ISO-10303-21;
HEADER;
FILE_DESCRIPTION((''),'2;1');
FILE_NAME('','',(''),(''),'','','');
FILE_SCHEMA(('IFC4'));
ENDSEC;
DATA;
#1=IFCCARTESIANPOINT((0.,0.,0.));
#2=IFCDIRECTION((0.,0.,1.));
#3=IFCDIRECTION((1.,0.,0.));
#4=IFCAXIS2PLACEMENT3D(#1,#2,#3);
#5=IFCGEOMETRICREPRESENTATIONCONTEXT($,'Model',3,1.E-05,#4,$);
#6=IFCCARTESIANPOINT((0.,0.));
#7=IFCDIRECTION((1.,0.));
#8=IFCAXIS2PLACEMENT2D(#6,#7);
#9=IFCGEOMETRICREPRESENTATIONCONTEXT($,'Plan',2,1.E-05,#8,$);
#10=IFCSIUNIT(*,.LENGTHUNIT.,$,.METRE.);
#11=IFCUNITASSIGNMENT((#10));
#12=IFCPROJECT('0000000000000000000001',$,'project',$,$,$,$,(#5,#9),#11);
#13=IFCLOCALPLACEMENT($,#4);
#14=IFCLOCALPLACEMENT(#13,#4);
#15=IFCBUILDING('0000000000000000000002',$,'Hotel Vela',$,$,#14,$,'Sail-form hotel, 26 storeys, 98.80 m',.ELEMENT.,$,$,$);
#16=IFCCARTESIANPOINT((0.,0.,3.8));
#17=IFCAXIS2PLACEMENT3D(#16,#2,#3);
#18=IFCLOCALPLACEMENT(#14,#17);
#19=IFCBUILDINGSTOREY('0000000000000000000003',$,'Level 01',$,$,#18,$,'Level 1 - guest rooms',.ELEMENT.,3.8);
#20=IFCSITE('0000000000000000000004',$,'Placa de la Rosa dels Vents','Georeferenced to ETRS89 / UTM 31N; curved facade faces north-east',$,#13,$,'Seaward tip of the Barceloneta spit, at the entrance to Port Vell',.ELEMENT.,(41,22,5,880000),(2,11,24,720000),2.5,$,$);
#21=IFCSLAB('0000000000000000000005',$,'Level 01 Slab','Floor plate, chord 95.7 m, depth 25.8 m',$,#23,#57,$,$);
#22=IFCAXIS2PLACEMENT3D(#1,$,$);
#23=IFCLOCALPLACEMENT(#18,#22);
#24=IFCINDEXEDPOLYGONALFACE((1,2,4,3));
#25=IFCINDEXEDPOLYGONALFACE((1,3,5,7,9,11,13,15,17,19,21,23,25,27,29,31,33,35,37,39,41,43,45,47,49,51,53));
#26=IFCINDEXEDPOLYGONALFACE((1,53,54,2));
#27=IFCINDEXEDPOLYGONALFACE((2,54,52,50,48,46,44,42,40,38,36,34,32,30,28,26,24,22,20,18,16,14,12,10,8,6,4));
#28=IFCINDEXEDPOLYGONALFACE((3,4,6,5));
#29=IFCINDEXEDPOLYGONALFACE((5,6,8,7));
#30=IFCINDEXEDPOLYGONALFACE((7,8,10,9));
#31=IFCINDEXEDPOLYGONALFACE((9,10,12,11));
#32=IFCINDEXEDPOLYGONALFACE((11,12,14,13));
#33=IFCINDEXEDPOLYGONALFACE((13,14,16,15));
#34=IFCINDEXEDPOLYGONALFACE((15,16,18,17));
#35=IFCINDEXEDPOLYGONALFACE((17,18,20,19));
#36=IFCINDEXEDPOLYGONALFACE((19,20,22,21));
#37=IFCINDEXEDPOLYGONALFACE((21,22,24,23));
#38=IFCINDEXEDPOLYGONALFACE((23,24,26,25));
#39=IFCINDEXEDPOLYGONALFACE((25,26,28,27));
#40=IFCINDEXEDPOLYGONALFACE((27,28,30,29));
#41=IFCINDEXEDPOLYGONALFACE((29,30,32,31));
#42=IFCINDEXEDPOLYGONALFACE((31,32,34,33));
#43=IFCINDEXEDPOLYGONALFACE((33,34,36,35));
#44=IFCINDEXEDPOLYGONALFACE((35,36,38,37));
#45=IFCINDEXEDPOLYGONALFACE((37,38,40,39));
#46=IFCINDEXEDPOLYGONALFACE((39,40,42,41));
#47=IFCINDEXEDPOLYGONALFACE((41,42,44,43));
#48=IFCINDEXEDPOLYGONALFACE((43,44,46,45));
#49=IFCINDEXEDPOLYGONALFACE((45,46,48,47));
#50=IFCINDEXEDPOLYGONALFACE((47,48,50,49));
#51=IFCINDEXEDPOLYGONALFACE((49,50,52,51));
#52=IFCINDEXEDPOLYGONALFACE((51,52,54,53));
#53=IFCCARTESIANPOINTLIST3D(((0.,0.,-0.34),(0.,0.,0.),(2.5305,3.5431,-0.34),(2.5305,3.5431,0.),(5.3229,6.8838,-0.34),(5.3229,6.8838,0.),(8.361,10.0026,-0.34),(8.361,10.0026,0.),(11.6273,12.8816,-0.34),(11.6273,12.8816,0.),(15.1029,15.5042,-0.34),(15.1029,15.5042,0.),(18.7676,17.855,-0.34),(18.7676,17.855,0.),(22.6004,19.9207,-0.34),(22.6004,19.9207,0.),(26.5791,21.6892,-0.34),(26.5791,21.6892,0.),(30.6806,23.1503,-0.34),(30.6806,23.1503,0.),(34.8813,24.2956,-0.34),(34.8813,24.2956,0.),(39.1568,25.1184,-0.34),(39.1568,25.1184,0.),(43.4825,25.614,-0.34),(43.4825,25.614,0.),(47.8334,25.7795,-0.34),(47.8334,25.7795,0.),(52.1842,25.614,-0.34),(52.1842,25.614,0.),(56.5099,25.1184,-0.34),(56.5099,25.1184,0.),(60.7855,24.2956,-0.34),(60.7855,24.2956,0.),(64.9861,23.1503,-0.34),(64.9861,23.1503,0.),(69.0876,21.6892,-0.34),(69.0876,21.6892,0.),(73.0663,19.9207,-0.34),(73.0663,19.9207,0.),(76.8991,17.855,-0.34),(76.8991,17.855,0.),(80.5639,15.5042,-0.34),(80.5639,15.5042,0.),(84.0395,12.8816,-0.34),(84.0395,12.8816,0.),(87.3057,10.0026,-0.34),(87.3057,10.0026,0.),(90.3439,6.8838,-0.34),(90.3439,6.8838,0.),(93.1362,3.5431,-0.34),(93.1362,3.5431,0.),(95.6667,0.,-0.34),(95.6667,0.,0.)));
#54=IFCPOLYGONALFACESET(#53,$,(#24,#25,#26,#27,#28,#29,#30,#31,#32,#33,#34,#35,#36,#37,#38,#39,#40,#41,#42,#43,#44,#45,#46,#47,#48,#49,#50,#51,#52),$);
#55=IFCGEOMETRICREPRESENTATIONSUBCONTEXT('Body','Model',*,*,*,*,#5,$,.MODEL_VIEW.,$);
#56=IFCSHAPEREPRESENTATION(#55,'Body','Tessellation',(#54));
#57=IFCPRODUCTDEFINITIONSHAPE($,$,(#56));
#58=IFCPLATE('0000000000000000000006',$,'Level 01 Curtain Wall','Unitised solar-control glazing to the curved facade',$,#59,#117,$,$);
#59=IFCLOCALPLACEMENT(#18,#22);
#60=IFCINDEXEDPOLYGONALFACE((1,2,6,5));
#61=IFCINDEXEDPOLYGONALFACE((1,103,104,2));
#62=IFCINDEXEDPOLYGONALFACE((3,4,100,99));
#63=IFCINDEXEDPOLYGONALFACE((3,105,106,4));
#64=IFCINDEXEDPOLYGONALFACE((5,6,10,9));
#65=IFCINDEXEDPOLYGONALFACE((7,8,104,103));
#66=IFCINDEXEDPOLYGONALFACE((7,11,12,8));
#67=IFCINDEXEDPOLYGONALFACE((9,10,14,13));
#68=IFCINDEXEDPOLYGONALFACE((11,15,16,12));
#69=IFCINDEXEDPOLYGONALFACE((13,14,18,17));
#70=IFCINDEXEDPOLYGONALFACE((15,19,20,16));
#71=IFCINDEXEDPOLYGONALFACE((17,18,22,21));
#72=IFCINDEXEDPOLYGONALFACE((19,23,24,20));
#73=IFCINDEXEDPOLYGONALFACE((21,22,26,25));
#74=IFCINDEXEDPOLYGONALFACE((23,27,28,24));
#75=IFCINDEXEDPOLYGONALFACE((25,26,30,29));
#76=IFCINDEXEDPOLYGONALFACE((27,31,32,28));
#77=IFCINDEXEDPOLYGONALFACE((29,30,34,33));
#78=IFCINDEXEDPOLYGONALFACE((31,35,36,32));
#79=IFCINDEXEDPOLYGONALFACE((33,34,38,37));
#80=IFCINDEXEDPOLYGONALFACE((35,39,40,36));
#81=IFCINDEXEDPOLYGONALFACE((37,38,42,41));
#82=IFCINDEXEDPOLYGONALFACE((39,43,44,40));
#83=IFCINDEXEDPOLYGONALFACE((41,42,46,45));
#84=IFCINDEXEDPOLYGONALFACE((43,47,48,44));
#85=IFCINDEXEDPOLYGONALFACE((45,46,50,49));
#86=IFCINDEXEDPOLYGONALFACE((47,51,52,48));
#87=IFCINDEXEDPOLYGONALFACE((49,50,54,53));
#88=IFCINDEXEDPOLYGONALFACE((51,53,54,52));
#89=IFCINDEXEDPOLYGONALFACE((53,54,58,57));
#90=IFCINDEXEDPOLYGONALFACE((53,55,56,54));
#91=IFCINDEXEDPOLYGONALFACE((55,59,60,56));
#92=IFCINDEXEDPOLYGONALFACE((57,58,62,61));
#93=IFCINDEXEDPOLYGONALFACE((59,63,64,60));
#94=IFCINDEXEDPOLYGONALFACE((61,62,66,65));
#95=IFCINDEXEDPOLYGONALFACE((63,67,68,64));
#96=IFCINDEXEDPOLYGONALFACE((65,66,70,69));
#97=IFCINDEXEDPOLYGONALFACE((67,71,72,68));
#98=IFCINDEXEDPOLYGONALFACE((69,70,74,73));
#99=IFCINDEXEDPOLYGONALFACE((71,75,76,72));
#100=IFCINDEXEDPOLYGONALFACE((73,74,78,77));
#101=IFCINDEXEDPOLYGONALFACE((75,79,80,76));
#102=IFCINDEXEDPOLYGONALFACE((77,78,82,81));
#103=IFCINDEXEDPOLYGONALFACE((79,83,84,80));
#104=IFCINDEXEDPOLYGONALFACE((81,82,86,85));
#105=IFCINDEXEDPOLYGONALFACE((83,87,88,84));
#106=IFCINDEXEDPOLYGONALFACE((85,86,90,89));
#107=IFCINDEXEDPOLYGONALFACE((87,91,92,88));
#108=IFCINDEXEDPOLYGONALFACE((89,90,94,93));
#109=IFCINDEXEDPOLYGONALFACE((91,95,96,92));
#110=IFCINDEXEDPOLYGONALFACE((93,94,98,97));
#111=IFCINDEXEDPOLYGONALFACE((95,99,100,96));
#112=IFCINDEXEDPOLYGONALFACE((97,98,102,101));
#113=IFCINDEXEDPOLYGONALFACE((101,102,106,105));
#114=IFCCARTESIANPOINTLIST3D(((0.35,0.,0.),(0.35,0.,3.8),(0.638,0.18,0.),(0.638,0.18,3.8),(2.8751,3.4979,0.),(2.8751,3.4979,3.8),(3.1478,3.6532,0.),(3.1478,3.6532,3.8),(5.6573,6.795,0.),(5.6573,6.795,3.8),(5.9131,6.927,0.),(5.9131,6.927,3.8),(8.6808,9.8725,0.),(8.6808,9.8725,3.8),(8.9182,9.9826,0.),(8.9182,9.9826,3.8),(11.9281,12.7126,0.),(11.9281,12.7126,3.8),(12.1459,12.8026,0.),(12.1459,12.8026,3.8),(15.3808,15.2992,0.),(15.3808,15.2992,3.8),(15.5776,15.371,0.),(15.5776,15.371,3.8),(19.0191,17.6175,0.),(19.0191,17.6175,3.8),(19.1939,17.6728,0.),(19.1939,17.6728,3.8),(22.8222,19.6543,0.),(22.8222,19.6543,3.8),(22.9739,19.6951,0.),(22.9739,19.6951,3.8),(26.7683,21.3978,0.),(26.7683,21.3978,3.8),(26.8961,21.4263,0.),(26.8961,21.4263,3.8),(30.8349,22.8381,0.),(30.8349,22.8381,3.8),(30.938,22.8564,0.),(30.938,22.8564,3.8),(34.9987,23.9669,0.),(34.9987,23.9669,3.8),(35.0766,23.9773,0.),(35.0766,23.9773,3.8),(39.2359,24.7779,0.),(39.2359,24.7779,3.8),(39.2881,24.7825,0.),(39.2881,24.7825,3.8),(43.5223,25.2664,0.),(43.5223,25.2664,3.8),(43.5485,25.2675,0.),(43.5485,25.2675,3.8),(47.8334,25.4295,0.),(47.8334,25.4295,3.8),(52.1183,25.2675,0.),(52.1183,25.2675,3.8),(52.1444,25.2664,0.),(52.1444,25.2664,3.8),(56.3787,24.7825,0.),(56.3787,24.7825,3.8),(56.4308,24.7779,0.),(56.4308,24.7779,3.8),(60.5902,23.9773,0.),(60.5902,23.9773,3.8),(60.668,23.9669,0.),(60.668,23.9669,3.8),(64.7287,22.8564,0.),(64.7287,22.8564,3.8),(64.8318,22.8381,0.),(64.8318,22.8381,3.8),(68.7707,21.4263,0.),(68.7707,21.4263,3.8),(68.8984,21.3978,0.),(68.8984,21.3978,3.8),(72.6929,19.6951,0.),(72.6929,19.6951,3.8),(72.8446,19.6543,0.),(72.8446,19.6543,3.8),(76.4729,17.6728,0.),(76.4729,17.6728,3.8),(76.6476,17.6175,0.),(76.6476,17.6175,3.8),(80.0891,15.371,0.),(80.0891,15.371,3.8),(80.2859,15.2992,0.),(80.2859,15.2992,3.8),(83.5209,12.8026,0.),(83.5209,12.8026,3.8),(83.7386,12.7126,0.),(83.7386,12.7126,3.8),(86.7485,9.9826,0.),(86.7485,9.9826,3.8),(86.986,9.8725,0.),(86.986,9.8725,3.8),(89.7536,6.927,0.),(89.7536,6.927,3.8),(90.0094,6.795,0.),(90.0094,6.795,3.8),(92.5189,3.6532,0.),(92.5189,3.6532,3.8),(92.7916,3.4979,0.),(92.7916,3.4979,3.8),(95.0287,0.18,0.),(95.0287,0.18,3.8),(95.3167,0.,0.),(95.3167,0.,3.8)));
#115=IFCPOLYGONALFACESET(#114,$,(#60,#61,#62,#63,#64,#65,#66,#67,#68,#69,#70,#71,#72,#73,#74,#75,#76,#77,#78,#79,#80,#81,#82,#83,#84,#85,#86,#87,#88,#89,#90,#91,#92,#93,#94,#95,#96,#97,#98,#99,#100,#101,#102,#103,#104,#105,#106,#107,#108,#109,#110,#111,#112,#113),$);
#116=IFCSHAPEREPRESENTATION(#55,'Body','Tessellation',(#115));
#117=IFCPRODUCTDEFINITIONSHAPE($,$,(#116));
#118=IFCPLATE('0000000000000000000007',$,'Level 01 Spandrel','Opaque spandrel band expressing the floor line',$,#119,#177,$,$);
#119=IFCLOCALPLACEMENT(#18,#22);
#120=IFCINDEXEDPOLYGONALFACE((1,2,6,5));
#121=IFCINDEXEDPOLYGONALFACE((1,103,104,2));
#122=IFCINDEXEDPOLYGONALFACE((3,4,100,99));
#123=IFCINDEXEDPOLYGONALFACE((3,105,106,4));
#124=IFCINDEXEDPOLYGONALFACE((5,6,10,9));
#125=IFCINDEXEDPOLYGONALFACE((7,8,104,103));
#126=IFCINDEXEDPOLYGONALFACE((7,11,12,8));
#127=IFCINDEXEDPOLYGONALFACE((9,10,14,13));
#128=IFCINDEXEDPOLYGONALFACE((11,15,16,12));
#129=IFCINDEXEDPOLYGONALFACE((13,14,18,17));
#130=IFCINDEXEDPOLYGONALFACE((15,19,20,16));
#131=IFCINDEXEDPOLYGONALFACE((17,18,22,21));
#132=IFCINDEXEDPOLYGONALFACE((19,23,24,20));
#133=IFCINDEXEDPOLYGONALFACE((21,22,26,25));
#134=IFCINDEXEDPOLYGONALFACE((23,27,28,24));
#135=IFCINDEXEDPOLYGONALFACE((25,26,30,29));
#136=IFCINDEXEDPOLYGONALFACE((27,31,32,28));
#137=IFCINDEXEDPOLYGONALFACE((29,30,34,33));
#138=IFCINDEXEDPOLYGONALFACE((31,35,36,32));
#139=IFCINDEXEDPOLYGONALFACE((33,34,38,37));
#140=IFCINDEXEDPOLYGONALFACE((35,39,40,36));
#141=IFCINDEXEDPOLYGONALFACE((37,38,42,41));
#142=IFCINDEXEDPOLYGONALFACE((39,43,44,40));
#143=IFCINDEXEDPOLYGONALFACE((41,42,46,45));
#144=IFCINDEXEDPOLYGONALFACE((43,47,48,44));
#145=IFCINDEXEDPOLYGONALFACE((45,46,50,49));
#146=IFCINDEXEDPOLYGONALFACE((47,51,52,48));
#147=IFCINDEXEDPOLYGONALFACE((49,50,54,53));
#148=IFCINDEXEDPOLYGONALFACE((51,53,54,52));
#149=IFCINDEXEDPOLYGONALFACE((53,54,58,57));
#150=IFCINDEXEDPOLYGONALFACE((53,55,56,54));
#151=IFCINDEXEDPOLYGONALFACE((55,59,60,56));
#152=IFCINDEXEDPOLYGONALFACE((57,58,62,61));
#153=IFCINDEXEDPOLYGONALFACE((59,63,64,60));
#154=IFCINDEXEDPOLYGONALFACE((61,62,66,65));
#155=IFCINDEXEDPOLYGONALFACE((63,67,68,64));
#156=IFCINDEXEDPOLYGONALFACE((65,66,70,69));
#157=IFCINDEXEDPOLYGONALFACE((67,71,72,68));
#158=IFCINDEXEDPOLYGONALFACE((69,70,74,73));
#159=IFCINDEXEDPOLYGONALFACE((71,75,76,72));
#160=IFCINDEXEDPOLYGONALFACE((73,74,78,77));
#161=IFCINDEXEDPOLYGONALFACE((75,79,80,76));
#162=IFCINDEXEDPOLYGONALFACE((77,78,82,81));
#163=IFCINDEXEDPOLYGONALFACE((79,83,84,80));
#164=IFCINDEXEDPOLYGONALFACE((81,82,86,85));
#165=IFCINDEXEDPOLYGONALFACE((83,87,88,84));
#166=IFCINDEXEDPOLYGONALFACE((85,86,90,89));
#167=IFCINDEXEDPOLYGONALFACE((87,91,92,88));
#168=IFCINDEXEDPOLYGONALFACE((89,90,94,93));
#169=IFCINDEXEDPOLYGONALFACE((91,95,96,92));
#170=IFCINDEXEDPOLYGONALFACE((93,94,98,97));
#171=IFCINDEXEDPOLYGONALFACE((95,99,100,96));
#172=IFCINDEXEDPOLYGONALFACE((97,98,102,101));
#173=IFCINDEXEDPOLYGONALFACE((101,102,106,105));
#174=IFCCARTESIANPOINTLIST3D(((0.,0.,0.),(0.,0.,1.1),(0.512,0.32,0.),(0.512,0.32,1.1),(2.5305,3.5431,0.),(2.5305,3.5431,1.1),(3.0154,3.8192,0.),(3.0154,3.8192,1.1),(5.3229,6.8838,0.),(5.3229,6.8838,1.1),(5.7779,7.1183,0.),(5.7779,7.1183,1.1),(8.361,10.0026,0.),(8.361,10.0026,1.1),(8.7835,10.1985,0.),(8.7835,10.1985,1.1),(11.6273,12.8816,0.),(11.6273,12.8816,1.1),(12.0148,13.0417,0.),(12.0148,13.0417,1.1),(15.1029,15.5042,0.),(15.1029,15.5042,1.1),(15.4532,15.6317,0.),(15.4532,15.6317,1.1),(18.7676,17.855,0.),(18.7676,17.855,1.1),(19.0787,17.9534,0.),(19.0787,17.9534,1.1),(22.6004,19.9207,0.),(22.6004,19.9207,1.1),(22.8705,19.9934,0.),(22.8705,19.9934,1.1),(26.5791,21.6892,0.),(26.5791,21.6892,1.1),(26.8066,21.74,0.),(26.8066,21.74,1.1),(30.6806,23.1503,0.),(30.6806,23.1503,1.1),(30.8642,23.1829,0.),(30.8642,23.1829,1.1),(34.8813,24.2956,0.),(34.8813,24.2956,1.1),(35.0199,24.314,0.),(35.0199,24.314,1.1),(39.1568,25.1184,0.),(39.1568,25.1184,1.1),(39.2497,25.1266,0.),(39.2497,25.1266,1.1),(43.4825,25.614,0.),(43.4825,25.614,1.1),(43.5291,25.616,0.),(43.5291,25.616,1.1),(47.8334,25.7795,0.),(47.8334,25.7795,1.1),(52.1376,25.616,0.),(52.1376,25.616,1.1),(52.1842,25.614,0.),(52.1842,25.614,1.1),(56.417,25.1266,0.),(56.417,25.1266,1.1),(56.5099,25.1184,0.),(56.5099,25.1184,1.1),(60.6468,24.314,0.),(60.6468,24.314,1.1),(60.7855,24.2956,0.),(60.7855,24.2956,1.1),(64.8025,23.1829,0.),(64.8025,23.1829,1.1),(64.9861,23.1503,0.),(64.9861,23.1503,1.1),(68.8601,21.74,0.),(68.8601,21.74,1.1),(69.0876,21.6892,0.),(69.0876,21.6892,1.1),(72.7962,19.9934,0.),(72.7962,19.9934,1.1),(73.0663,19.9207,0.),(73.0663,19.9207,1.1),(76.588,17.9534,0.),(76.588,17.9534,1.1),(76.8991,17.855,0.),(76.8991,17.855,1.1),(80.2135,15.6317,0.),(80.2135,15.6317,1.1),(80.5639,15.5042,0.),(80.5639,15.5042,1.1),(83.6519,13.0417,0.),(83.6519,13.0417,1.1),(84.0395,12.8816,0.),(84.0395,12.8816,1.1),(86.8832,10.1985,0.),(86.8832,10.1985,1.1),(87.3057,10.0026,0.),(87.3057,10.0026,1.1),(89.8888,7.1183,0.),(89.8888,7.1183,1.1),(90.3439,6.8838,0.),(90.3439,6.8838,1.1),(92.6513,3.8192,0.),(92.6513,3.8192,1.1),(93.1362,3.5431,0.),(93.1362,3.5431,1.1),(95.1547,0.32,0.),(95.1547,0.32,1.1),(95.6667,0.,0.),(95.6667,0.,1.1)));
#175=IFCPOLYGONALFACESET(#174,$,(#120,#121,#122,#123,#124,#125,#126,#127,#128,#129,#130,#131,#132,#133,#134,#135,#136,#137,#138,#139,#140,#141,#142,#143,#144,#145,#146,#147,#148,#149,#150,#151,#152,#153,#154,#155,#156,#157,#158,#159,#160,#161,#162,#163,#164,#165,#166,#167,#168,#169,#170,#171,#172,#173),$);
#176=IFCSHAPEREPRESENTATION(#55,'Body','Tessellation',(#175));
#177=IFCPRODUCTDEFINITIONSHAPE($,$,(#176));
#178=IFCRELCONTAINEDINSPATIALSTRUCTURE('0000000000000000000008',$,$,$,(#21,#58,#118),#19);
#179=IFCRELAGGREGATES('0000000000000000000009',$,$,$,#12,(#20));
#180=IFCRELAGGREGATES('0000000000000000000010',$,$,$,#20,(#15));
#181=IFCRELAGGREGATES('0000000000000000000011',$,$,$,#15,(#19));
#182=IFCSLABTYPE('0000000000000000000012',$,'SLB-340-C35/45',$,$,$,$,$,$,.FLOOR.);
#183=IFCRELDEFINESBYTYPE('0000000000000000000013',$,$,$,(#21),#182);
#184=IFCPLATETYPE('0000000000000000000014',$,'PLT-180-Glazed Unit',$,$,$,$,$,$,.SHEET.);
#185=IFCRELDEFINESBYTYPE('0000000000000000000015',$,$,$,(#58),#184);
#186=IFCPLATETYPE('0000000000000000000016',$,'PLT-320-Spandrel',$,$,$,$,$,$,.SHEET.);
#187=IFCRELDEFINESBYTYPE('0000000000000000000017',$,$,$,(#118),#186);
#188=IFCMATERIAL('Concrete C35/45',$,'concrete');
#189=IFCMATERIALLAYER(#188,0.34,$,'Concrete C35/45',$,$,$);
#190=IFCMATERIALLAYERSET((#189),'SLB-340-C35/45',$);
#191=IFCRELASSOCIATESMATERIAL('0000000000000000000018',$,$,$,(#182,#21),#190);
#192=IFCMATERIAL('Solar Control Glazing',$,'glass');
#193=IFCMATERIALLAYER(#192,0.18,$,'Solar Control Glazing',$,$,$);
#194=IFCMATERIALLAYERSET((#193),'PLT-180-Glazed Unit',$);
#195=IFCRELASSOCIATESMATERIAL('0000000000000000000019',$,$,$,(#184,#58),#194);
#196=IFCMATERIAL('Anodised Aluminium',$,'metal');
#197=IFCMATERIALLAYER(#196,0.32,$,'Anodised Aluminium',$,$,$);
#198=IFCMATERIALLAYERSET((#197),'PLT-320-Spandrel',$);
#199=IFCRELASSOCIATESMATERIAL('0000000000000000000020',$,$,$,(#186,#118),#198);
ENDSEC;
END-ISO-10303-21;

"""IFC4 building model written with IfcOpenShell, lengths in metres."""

from ifc_helpers import new_model, si_unit, frame, origin_with_axes, origin_2d_with_axis, place, context, subcontext, project, spatial, line, indexed_curve, outline, extrude, material, layer, layer_set, layer_usage, type_object, element, save


model = new_model("IFC4")

# Units and contexts
model_context = context("Model", 3, precision=1e-05, world=origin_with_axes())
plan_context = context("Plan", 2, precision=1e-05, world=origin_2d_with_axis())
body_context = subcontext(model_context, "Body", "Model", "MODEL_VIEW")
ifc_project = project(units=[si_unit("LENGTHUNIT", "METRE")], contexts=[model_context, plan_context])

# Site, building, storey
site_placement = place(None, origin_with_axes())
site = spatial("IfcSite", under=ifc_project, at=site_placement, Name="Placa de la Rosa dels Vents", Description="Georeferenced to ETRS89 / UTM 31N; curved facade faces north-east", LongName="Seaward tip of the Barceloneta spit, at the entrance to Port Vell", CompositionType="ELEMENT", RefLatitude=(41, 22, 5, 880000), RefLongitude=(2, 11, 24, 720000), RefElevation=2.5)
building_placement = place(site_placement, origin_with_axes())
building = spatial("IfcBuilding", under=site, at=building_placement, Name="Hotel Vela", LongName="Sail-form hotel, 26 storeys, 98.80 m", CompositionType="ELEMENT")
storey_placement = place(building_placement, frame((0.0, 0.0, 3.8), z_axis=(0.0, 0.0, 1.0), x_axis=(1.0, 0.0, 0.0)))
storey = spatial("IfcBuildingStorey", under=building, at=storey_placement, Name="Level 01", LongName="Level 1 - guest rooms", CompositionType="ELEMENT", Elevation=3.8)

# Slab
ifc_material_1 = material(Name="Concrete C35/45", Category="concrete")
ifc_layer_1 = layer(ifc_material_1, 0.34, Name="Concrete C35/45")
ifc_layer_set_1 = layer_set([ifc_layer_1], Name="SLB-340-C35/45")
ifc_layer_usage_1 = layer_usage(ifc_layer_set_1, "AXIS3", "POSITIVE", 0.0)
slab_type = type_object("IfcSlabType", Name="SLB-340-C35/45", PredefinedType="FLOOR", material=ifc_layer_set_1)
slab_placement = place(storey_placement, frame((0.0, 0.0, -0.34), z_axis=(0.0, 0.0, 1.0), x_axis=(1.0, 0.0, 0.0)))
element("IfcSlab", 1, at=slab_placement, inside=storey, type_object=slab_type, material=ifc_layer_usage_1, Name="Level 01 Slab", Description="Floor plate, chord 95.7 m, depth 25.8 m", context=body_context, shape_type="SweptSolid", body=[
    extrude(outline(indexed_curve([(0.0, 0.0), (95.6667, 0.0), (93.1362, 3.5431), (90.3439, 6.8838), (87.3057, 10.0026), (84.0395, 12.8816), (80.5639, 15.5042), (76.8991, 17.855), (73.0663, 19.9207), (69.0876, 21.6892), (64.9861, 23.1503), (60.7855, 24.2956), (56.5099, 25.1184), (52.1842, 25.614), (47.8334, 25.7795), (43.4825, 25.614), (39.1568, 25.1184), (34.8813, 24.2956), (30.6806, 23.1503), (26.5791, 21.6892), (22.6004, 19.9207), (18.7676, 17.855), (15.1029, 15.5042), (11.6273, 12.8816), (8.361, 10.0026), (5.3229, 6.8838), (2.5305, 3.5431)], segments=[line(1, 2, 3, 4, 5, 6, 7, 8, 9, 10, 11, 12, 13, 14, 15, 16, 17, 18, 19, 20, 21, 22, 23, 24, 25, 26, 27, 1)])), origin_with_axes(), (0.0, 0.0, 1.0), 0.34),
])

# Plates
ifc_material_2 = material(Name="Solar Control Glazing", Category="glass")
ifc_layer_2 = layer(ifc_material_2, 0.18, Name="Solar Control Glazing")
ifc_layer_set_2 = layer_set([ifc_layer_2], Name="PLT-180-Glazed Unit")
ifc_layer_usage_2 = layer_usage(ifc_layer_set_2, "AXIS2", "POSITIVE", 0.0)
plate_type_1 = type_object("IfcPlateType", Name="PLT-180-Glazed Unit", PredefinedType="SHEET", material=ifc_layer_set_2)
plate_1_placement = place(storey_placement, frame((0.35, 0.0, 0.0), z_axis=(0.0, 0.0, 1.0), x_axis=(1.0, 0.0, 0.0)))
element("IfcPlate", 2, at=plate_1_placement, inside=storey, type_object=plate_type_1, material=ifc_layer_usage_2, Name="Level 01 Curtain Wall", Description="Unitised solar-control glazing to the curved facade", context=body_context, shape_type="SweptSolid", body=[
    extrude(outline(indexed_curve([(94.9667, 0.0), (92.4416, 3.4979), (89.6594, 6.795), (86.636, 9.8725), (83.3886, 12.7126), (79.9359, 15.2992), (76.2976, 17.6175), (72.4946, 19.6543), (68.5484, 21.3978), (64.4818, 22.8381), (60.318, 23.9669), (56.0808, 24.7779), (51.7944, 25.2664), (47.4834, 25.4295), (43.1723, 25.2664), (38.8859, 24.7779), (34.6487, 23.9669), (30.4849, 22.8381), (26.4183, 21.3978), (22.4722, 19.6543), (18.6691, 17.6175), (15.0308, 15.2992), (11.5781, 12.7126), (8.3308, 9.8725), (5.3073, 6.795), (2.5251, 3.4979), (0.0, 0.0), (94.6787, 0.18), (2.7978, 3.6532), (5.5631, 6.927), (8.5682, 9.9826), (11.7959, 12.8026), (15.2276, 15.371), (18.8439, 17.6728), (22.6239, 19.6951), (26.5461, 21.4263), (30.588, 22.8564), (34.7266, 23.9773), (38.9381, 24.7825), (43.1985, 25.2675), (47.4834, 25.4295), (51.7683, 25.2675), (56.0287, 24.7825), (60.2402, 23.9773), (64.3787, 22.8564), (68.4207, 21.4263), (72.3429, 19.6951), (76.1229, 17.6728), (79.7391, 15.371), (83.1709, 12.8026), (86.3985, 9.9826), (89.4036, 6.927), (92.1689, 3.6532), (0.288, 0.18)], segments=[line(1, 2, 3, 4, 5, 6, 7, 8, 9, 10, 11, 12, 13, 14, 15, 16, 17, 18, 19, 20, 21, 22, 23, 24, 25, 26, 27, 28, 29, 30, 31, 32, 33, 34, 35, 36, 37, 38, 39, 40, 41, 42, 43, 44, 45, 46, 47, 48, 49, 50, 51, 52, 53, 54, 1)])), origin_with_axes(), (0.0, 0.0, 1.0), 3.8),
])
ifc_material_3 = material(Name="Anodised Aluminium", Category="metal")
ifc_layer_3 = layer(ifc_material_3, 0.32, Name="Anodised Aluminium")
ifc_layer_set_3 = layer_set([ifc_layer_3], Name="PLT-320-Spandrel")
ifc_layer_usage_3 = layer_usage(ifc_layer_set_3, "AXIS2", "POSITIVE", 0.0)
plate_type_2 = type_object("IfcPlateType", Name="PLT-320-Spandrel", PredefinedType="SHEET", material=ifc_layer_set_3)
plate_2_placement = place(storey_placement, origin_with_axes())
element("IfcPlate", 3, at=plate_2_placement, inside=storey, type_object=plate_type_2, material=ifc_layer_usage_3, Name="Level 01 Spandrel", Description="Opaque spandrel band expressing the floor line", context=body_context, shape_type="SweptSolid", body=[
    extrude(outline(indexed_curve([(95.6667, 0.0), (93.1362, 3.5431), (90.3439, 6.8838), (87.3057, 10.0026), (84.0395, 12.8816), (80.5639, 15.5042), (76.8991, 17.855), (73.0663, 19.9207), (69.0876, 21.6892), (64.9861, 23.1503), (60.7855, 24.2956), (56.5099, 25.1184), (52.1842, 25.614), (47.8334, 25.7795), (43.4825, 25.614), (39.1568, 25.1184), (34.8813, 24.2956), (30.6806, 23.1503), (26.5791, 21.6892), (22.6004, 19.9207), (18.7676, 17.855), (15.1029, 15.5042), (11.6273, 12.8816), (8.361, 10.0026), (5.3229, 6.8838), (2.5305, 3.5431), (0.0, 0.0), (95.1547, 0.32), (3.0154, 3.8192), (5.7779, 7.1183), (8.7835, 10.1985), (12.0148, 13.0417), (15.4532, 15.6317), (19.0787, 17.9534), (22.8705, 19.9934), (26.8066, 21.74), (30.8642, 23.1829), (35.0199, 24.314), (39.2497, 25.1266), (43.5291, 25.616), (47.8334, 25.7795), (52.1376, 25.616), (56.417, 25.1266), (60.6468, 24.314), (64.8025, 23.1829), (68.8601, 21.74), (72.7962, 19.9934), (76.588, 17.9534), (80.2135, 15.6317), (83.6519, 13.0417), (86.8832, 10.1985), (89.8888, 7.1183), (92.6513, 3.8192), (0.512, 0.32)], segments=[line(1, 2, 3, 4, 5, 6, 7, 8, 9, 10, 11, 12, 13, 14, 15, 16, 17, 18, 19, 20, 21, 22, 23, 24, 25, 26, 27, 28, 29, 30, 31, 32, 33, 34, 35, 36, 37, 38, 39, 40, 41, 42, 43, 44, 45, 46, 47, 48, 49, 50, 51, 52, 53, 54, 1)])), origin_with_axes(), (0.0, 0.0, 1.0), 1.1),
])

save(model, "model.ifc")
